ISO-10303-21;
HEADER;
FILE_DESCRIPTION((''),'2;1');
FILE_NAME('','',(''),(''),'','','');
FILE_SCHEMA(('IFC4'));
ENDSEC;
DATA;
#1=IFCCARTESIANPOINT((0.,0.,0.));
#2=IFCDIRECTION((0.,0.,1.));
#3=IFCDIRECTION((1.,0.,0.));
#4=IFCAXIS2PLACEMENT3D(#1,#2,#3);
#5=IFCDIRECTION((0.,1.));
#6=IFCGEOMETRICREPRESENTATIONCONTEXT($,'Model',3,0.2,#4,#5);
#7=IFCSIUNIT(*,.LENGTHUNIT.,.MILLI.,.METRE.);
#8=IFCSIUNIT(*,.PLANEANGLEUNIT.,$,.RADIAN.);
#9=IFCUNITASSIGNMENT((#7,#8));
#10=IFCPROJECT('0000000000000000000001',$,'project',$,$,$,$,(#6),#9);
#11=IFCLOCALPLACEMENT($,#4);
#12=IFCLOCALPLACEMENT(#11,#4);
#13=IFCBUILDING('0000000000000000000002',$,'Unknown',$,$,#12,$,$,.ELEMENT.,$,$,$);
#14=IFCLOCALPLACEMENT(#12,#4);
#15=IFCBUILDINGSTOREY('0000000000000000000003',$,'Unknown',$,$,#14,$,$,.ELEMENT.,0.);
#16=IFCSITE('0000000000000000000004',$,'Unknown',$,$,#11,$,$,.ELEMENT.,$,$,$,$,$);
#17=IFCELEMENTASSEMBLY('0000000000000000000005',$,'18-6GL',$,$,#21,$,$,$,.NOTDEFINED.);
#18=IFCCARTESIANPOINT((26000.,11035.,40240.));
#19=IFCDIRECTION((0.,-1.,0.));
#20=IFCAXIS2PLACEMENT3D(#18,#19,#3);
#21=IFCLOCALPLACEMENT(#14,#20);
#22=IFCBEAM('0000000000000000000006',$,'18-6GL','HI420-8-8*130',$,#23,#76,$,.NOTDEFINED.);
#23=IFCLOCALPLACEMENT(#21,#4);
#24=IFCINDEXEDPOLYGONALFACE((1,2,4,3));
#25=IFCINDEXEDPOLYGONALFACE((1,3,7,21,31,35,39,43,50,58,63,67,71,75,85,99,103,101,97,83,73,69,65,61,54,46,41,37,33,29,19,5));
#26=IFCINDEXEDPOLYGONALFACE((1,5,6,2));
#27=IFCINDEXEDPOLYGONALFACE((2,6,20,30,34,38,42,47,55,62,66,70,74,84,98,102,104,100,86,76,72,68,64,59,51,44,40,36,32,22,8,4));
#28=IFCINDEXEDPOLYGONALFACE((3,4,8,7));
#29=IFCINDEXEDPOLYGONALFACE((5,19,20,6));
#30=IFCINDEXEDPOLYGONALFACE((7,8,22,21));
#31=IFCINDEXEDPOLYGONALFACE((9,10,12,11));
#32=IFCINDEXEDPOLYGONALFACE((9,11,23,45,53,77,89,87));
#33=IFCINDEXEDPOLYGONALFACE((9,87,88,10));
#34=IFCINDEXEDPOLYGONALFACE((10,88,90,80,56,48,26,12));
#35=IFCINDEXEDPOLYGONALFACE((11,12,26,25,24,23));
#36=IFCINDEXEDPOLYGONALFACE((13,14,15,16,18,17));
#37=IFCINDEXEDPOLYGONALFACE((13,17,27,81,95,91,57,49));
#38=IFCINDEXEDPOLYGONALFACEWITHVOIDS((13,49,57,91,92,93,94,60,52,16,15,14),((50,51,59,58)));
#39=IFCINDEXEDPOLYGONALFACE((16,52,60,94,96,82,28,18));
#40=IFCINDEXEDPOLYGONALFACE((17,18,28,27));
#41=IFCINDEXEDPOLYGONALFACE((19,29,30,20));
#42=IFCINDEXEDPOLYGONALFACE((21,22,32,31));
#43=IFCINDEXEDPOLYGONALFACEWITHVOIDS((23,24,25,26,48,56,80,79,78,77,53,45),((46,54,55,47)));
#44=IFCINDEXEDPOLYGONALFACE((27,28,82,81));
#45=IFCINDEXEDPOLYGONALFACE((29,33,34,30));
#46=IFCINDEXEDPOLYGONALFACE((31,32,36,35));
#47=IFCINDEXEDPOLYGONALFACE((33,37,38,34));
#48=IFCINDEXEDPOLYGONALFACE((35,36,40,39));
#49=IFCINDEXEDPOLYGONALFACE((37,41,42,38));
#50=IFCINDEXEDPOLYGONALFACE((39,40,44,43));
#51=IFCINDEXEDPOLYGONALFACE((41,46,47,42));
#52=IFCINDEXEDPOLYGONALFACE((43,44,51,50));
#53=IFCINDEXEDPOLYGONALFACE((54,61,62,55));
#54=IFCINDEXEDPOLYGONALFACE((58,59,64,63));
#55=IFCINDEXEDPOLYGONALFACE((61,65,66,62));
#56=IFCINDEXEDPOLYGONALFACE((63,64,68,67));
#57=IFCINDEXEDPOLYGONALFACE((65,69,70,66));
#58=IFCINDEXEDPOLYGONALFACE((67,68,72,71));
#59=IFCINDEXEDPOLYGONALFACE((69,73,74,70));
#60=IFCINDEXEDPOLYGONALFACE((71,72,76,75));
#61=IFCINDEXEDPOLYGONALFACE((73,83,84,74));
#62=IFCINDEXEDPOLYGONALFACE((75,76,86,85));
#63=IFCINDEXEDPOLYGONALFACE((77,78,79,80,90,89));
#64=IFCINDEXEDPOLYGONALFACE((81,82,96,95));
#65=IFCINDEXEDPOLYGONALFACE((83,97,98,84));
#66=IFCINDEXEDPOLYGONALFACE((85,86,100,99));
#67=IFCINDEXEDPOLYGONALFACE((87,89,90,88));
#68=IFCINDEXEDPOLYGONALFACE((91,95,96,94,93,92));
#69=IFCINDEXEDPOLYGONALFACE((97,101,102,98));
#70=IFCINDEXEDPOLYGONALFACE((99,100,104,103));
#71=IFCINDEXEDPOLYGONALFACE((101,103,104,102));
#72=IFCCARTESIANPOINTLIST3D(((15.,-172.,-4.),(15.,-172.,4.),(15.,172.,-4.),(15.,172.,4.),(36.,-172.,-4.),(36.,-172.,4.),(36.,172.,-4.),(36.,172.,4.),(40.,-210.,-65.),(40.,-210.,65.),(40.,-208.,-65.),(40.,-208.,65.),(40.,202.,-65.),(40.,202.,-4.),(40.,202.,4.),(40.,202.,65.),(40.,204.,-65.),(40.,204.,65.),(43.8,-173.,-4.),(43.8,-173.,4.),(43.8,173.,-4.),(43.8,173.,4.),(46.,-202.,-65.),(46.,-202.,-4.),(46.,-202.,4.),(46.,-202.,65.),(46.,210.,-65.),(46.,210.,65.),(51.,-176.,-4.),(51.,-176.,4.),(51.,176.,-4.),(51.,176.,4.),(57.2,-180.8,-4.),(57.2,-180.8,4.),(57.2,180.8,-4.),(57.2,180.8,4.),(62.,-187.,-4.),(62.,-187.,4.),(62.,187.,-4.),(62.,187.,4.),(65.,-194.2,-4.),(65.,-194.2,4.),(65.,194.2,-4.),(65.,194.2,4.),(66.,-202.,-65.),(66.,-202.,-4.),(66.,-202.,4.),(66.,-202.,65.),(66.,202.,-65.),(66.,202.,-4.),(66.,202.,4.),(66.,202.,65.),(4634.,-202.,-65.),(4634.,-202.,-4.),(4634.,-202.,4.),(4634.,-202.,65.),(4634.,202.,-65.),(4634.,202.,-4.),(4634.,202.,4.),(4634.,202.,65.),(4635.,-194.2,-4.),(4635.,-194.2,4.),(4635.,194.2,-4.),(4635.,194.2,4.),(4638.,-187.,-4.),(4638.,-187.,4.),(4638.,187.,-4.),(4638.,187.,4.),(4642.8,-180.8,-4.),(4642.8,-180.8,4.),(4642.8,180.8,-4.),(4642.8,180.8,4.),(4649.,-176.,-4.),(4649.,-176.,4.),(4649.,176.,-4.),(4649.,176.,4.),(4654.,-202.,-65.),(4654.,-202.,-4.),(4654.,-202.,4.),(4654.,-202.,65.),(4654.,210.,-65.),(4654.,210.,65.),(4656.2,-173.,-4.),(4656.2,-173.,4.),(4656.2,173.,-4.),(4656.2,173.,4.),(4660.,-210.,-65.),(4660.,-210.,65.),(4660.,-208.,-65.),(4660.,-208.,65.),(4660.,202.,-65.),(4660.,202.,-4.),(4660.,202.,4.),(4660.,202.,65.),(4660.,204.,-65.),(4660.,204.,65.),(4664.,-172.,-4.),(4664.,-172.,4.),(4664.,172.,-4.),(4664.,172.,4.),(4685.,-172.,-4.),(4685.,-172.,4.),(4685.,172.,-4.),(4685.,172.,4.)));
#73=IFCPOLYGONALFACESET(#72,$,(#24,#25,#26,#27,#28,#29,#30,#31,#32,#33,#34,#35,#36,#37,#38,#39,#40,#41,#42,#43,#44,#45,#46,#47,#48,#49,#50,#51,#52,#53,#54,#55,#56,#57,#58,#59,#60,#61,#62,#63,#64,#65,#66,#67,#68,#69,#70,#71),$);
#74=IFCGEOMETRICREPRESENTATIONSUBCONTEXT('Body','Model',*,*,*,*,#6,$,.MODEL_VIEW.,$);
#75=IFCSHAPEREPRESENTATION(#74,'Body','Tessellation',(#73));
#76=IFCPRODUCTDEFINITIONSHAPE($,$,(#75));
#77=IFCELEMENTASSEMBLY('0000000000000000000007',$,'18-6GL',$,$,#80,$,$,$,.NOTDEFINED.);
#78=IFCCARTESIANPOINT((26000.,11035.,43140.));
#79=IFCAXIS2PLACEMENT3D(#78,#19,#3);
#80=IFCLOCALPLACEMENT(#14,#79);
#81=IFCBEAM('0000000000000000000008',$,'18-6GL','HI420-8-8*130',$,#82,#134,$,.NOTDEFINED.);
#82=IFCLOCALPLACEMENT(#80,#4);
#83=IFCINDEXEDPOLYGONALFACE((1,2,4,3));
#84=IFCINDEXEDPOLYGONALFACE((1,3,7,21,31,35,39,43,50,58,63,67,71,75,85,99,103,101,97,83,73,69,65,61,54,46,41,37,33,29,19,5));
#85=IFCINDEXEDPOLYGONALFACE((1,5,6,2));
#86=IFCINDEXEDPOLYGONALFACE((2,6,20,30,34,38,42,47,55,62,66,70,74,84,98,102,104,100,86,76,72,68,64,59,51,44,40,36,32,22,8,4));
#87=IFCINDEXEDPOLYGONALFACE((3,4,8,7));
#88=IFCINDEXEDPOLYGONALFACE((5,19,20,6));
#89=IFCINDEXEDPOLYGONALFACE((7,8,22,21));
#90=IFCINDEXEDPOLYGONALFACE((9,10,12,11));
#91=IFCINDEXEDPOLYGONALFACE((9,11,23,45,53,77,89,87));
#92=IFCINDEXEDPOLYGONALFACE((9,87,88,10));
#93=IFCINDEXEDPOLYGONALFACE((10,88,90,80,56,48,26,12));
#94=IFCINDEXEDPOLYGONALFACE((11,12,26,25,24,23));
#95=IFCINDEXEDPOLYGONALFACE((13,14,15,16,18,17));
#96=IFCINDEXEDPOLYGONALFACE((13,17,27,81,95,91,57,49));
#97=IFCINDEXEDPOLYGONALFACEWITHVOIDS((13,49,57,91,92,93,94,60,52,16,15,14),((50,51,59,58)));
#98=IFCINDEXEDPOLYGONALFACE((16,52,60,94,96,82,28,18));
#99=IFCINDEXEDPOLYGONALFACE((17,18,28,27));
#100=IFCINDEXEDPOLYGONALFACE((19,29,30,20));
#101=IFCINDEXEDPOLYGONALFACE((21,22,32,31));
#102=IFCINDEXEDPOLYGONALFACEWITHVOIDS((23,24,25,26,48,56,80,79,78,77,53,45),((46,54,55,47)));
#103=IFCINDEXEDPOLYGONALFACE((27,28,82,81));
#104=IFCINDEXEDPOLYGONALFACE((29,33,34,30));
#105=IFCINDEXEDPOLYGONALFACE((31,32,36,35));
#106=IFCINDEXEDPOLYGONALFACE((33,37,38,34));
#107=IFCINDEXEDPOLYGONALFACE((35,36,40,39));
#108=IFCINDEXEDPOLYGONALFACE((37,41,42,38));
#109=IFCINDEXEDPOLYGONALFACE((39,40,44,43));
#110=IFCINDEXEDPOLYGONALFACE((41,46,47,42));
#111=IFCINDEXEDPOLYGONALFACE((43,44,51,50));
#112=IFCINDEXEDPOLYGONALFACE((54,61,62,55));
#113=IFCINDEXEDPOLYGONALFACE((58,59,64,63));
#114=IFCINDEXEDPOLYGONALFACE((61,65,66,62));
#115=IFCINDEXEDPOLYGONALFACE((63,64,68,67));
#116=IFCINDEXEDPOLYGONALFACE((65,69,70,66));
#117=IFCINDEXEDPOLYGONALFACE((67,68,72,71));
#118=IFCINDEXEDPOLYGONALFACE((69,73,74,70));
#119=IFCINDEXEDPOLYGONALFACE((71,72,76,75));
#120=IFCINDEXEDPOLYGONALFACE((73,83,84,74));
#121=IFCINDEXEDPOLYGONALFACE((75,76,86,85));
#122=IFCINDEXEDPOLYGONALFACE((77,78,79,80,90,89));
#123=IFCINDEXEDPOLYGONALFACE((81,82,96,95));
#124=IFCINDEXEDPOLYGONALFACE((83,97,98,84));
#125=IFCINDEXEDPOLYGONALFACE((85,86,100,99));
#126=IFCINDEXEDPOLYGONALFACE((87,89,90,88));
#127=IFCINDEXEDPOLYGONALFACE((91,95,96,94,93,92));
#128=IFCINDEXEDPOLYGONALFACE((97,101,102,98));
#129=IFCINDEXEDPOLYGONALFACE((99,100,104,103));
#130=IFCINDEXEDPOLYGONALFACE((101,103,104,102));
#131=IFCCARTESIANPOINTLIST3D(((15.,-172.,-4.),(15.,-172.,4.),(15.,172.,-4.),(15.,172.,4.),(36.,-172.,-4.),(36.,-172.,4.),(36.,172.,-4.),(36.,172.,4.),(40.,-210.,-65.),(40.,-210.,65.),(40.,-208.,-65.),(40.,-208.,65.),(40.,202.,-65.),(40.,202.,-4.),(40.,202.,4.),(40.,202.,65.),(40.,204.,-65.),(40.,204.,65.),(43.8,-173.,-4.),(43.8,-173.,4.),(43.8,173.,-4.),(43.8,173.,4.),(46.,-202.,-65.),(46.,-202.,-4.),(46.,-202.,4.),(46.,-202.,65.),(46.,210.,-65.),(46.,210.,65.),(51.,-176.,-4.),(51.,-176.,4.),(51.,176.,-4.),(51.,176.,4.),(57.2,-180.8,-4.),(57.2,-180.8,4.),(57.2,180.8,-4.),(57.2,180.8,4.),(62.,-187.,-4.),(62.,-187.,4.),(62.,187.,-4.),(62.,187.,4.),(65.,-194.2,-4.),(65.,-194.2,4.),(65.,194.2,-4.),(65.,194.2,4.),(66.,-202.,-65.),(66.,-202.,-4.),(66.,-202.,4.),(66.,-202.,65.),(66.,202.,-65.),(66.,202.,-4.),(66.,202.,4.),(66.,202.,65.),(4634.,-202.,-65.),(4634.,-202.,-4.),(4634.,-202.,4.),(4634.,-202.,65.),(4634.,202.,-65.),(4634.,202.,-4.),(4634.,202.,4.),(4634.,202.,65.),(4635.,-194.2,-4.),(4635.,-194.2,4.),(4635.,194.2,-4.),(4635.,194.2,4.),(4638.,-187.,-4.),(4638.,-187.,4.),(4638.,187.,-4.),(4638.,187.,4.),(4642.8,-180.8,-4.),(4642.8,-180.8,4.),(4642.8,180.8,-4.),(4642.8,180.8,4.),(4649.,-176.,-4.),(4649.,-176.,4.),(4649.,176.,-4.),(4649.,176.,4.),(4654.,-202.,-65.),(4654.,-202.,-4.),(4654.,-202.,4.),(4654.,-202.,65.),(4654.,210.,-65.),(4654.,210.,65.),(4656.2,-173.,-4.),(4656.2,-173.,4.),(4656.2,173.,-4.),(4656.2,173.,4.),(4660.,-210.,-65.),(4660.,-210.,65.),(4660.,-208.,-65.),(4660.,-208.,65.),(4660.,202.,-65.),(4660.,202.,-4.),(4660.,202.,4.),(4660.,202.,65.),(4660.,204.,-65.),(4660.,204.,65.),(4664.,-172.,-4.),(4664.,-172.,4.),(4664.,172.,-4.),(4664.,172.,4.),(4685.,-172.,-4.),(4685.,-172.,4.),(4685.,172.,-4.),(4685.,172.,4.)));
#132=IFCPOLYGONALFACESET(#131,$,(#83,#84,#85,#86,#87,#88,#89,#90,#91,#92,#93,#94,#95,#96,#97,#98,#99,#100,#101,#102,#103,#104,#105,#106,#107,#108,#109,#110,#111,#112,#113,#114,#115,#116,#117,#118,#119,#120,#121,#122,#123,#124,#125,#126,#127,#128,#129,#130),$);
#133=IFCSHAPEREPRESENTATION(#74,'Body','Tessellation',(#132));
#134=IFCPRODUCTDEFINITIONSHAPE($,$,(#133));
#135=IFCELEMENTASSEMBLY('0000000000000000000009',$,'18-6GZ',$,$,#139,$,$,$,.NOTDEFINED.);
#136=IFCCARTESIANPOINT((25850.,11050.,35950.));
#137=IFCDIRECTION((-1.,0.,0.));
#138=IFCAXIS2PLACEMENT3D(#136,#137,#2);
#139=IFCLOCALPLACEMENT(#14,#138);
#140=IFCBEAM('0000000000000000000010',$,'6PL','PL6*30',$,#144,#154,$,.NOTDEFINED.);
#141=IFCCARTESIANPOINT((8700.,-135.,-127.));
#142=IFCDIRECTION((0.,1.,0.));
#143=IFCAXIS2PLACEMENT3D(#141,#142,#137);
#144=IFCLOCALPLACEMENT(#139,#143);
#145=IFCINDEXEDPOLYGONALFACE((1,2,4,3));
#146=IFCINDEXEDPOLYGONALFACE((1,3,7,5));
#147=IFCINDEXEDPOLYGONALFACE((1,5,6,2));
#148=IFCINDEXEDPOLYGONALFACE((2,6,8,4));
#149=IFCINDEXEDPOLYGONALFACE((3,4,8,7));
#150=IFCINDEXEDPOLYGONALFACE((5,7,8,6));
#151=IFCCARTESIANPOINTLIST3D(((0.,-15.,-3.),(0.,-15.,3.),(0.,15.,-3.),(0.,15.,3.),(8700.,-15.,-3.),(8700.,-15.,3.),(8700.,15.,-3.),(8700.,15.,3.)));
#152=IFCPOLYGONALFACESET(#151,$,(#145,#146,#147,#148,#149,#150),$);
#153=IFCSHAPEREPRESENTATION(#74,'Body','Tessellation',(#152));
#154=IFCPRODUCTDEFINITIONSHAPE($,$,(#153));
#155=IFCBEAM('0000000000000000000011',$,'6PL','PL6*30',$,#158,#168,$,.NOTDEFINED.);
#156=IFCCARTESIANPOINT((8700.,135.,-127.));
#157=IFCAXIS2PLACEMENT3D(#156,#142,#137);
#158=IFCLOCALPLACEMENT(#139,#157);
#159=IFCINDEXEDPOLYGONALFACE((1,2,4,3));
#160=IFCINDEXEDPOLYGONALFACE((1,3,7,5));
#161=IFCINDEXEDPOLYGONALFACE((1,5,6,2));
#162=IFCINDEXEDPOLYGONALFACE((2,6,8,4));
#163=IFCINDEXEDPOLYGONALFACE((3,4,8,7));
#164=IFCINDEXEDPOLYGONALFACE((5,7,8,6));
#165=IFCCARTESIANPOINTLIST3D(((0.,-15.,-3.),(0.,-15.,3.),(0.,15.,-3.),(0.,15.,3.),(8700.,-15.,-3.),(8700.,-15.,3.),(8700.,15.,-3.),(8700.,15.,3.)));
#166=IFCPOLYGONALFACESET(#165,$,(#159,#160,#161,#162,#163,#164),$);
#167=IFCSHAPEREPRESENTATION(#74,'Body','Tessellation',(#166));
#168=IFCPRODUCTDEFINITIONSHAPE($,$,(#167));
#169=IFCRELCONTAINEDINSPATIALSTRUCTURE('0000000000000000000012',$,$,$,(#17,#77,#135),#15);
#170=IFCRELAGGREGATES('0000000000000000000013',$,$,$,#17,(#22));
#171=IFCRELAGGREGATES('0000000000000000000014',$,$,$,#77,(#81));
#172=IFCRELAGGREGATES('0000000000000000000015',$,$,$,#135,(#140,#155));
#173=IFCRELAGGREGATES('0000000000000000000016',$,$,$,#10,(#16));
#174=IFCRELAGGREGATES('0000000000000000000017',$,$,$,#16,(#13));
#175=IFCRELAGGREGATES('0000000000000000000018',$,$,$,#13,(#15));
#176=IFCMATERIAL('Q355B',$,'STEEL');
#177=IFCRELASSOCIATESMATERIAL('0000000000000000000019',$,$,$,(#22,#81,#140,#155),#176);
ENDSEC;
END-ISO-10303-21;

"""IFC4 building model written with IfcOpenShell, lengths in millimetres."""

from ifc_helpers import new_model, si_unit, direction, frame, origin_with_axes, place, context, subcontext, project, spatial, line, arc, indexed_curve, outline, extrude, material, element, aggregate, save


model = new_model("IFC4")

# Units and contexts
model_context = context("Model", 3, precision=0.2, world=origin_with_axes(), true_north=direction((0.0, 1.0)))
body_context = subcontext(model_context, "Body", "Model", "MODEL_VIEW")
ifc_project = project(units=[si_unit("LENGTHUNIT", "METRE", prefix="MILLI"), si_unit("PLANEANGLEUNIT", "RADIAN")], contexts=[model_context])

# Site, building, storey
site_placement = place(None, origin_with_axes())
site = spatial("IfcSite", under=ifc_project, at=site_placement, Name="Unknown", CompositionType="ELEMENT")
building_placement = place(site_placement, origin_with_axes())
building = spatial("IfcBuilding", under=site, at=building_placement, Name="Unknown", CompositionType="ELEMENT")
storey_placement = place(building_placement, origin_with_axes())
storey = spatial("IfcBuildingStorey", under=building, at=storey_placement, Name="Unknown", CompositionType="ELEMENT", Elevation=0.0)

# Element assembly, beam, voiding features
assembly_1_placement = place(storey_placement, frame((26000.0, 11035.0, 40240.0), z_axis=(0.0, -1.0, 0.0), x_axis=(1.0, 0.0, 0.0)))
assembly_1 = element("IfcElementAssembly", 1, at=assembly_1_placement, inside=storey, Name="18-6GL", PredefinedType="NOTDEFINED")
ifc_material_1 = material(Name="Q355B", Category="STEEL")
beam_1_placement = place(assembly_1_placement, origin_with_axes())
beam_1 = element("IfcBeam", 2, at=beam_1_placement, material=ifc_material_1, Name="18-6GL", Description="HI420-8-8*130", PredefinedType="NOTDEFINED", context=body_context, shape_type="SolidModel", body=[
    extrude(outline(indexed_curve([(-65.0, -210.0), (65.0, -210.0), (65.0, -202.0), (4.0, -202.0), (4.0, 202.0), (65.0, 202.0), (65.0, 210.0), (-65.0, 210.0), (-65.0, 202.0), (-4.0, 202.0), (-4.0, -202.0), (-65.0, -202.0)], segments=[line(1, 2, 3, 4, 5, 6, 7, 8, 9, 10, 11, 12, 1)])), frame((0.0, 0.0, 0.0), z_axis=(-1.0, 0.0, 0.0), x_axis=(0.0, 0.0, 1.0)), (0.0, 0.0, -1.0), 4700.0),
])
voiding_feature_1_placement = place(beam_1_placement, frame((4700.0, 210.0, 0.0), z_axis=(0.0, 0.0, 1.0), x_axis=(-1.0, 0.0, 0.0)))
element("IfcVoidingFeature", 3, at=voiding_feature_1_placement, cuts=beam_1, Name="CUTPART", PredefinedType="HOLE", context=body_context, shape_type="SolidModel", body=[
    extrude(outline(indexed_curve([(0.0, 0.0), (46.0, 0.0), (40.0, 6.0), (40.0, 8.0), (66.0, 8.0), (57.2, 29.2), (36.0, 38.0), (15.0, 38.0), (15.0, 382.0), (36.0, 382.0), (57.2, 390.8), (66.0, 412.0), (46.0, 412.0), (40.0, 418.0), (40.0, 420.0), (0.0, 420.0)], segments=[line(1, 2, 3, 4, 5), arc(5, 6, 7), line(7, 8, 9, 10), arc(10, 11, 12), line(12, 13, 14, 15, 16, 1)])), frame((0.0, 0.0, 67.5), z_axis=(0.0, 0.0, 1.0), x_axis=(1.0, 0.0, 0.0)), (0.0, 0.0, -1.0), 135.0),
])
voiding_feature_2_placement = place(beam_1_placement, frame((0.0, 210.0, 0.0), z_axis=(0.0, 0.0, -1.0), x_axis=(1.0, 0.0, 0.0)))
element("IfcVoidingFeature", 4, at=voiding_feature_2_placement, cuts=beam_1, Name="CUTPART", PredefinedType="HOLE", context=body_context, shape_type="SolidModel", body=[
    extrude(outline(indexed_curve([(0.0, 0.0), (46.0, 0.0), (40.0, 6.0), (40.0, 8.0), (66.0, 8.0), (57.2, 29.2), (36.0, 38.0), (15.0, 38.0), (15.0, 382.0), (36.0, 382.0), (57.2, 390.8), (66.0, 412.0), (46.0, 412.0), (40.0, 418.0), (40.0, 420.0), (0.0, 420.0)], segments=[line(1, 2, 3, 4, 5), arc(5, 6, 7), line(7, 8, 9, 10), arc(10, 11, 12), line(12, 13, 14, 15, 16, 1)])), frame((0.0, 0.0, 67.5), z_axis=(0.0, 0.0, 1.0), x_axis=(1.0, 0.0, 0.0)), (0.0, 0.0, -1.0), 135.0),
])

# Element assembly, beam, voiding features
assembly_2_placement = place(storey_placement, frame((26000.0, 11035.0, 43140.0), z_axis=(0.0, -1.0, 0.0), x_axis=(1.0, 0.0, 0.0)))
assembly_2 = element("IfcElementAssembly", 5, at=assembly_2_placement, inside=storey, Name="18-6GL", PredefinedType="NOTDEFINED")
beam_2_placement = place(assembly_2_placement, origin_with_axes())
beam_2 = element("IfcBeam", 6, at=beam_2_placement, material=ifc_material_1, Name="18-6GL", Description="HI420-8-8*130", PredefinedType="NOTDEFINED", context=body_context, shape_type="SolidModel", body=[
    extrude(outline(indexed_curve([(-65.0, -210.0), (65.0, -210.0), (65.0, -202.0), (4.0, -202.0), (4.0, 202.0), (65.0, 202.0), (65.0, 210.0), (-65.0, 210.0), (-65.0, 202.0), (-4.0, 202.0), (-4.0, -202.0), (-65.0, -202.0)], segments=[line(1, 2, 3, 4, 5, 6, 7, 8, 9, 10, 11, 12, 1)])), frame((0.0, 0.0, 0.0), z_axis=(-1.0, 0.0, 0.0), x_axis=(0.0, 0.0, 1.0)), (0.0, 0.0, -1.0), 4700.0),
])
voiding_feature_3_placement = place(beam_2_placement, frame((4700.0, 210.0, 0.0), z_axis=(0.0, 0.0, 1.0), x_axis=(-1.0, 0.0, 0.0)))
element("IfcVoidingFeature", 7, at=voiding_feature_3_placement, cuts=beam_2, Name="CUTPART", PredefinedType="HOLE", context=body_context, shape_type="SolidModel", body=[
    extrude(outline(indexed_curve([(0.0, 0.0), (46.0, 0.0), (40.0, 6.0), (40.0, 8.0), (66.0, 8.0), (57.2, 29.2), (36.0, 38.0), (15.0, 38.0), (15.0, 382.0), (36.0, 382.0), (57.2, 390.8), (66.0, 412.0), (46.0, 412.0), (40.0, 418.0), (40.0, 420.0), (0.0, 420.0)], segments=[line(1, 2, 3, 4, 5), arc(5, 6, 7), line(7, 8, 9, 10), arc(10, 11, 12), line(12, 13, 14, 15, 16, 1)])), frame((0.0, 0.0, 67.5), z_axis=(0.0, 0.0, 1.0), x_axis=(1.0, 0.0, 0.0)), (0.0, 0.0, -1.0), 135.0),
])
voiding_feature_4_placement = place(beam_2_placement, frame((0.0, 210.0, 0.0), z_axis=(0.0, 0.0, -1.0), x_axis=(1.0, 0.0, 0.0)))
element("IfcVoidingFeature", 8, at=voiding_feature_4_placement, cuts=beam_2, Name="CUTPART", PredefinedType="HOLE", context=body_context, shape_type="SolidModel", body=[
    extrude(outline(indexed_curve([(0.0, 0.0), (46.0, 0.0), (40.0, 6.0), (40.0, 8.0), (66.0, 8.0), (57.2, 29.2), (36.0, 38.0), (15.0, 38.0), (15.0, 382.0), (36.0, 382.0), (57.2, 390.8), (66.0, 412.0), (46.0, 412.0), (40.0, 418.0), (40.0, 420.0), (0.0, 420.0)], segments=[line(1, 2, 3, 4, 5), arc(5, 6, 7), line(7, 8, 9, 10), arc(10, 11, 12), line(12, 13, 14, 15, 16, 1)])), frame((0.0, 0.0, 67.5), z_axis=(0.0, 0.0, 1.0), x_axis=(1.0, 0.0, 0.0)), (0.0, 0.0, -1.0), 135.0),
])

# Element assembly, beams
assembly_3_placement = place(storey_placement, frame((25850.0, 11050.0, 35950.0), z_axis=(-1.0, 0.0, 0.0), x_axis=(0.0, 0.0, 1.0)))
assembly_3 = element("IfcElementAssembly", 9, at=assembly_3_placement, inside=storey, Name="18-6GZ", PredefinedType="NOTDEFINED")
beam_3_placement = place(assembly_3_placement, frame((8700.0, -135.0, -127.0), z_axis=(0.0, 1.0, 0.0), x_axis=(-1.0, 0.0, 0.0)))
beam_3 = element("IfcBeam", 10, at=beam_3_placement, material=ifc_material_1, Name="6PL", Description="PL6*30", PredefinedType="NOTDEFINED", context=body_context, shape_type="SolidModel", body=[
    extrude(outline(indexed_curve([(-3.0, -15.0), (3.0, -15.0), (3.0, 15.0), (-3.0, 15.0)], segments=[line(1, 2, 3, 4, 1)])), frame((0.0, 0.0, 0.0), z_axis=(-1.0, 0.0, 0.0), x_axis=(0.0, 0.0, 1.0)), (0.0, 0.0, -1.0), 8700.0),
])
beam_4_placement = place(assembly_3_placement, frame((8700.0, 135.0, -127.0), z_axis=(0.0, 1.0, 0.0), x_axis=(-1.0, 0.0, 0.0)))
beam_4 = element("IfcBeam", 11, at=beam_4_placement, material=ifc_material_1, Name="6PL", Description="PL6*30", PredefinedType="NOTDEFINED", context=body_context, shape_type="SolidModel", body=[
    extrude(outline(indexed_curve([(-3.0, -15.0), (3.0, -15.0), (3.0, 15.0), (-3.0, 15.0)], segments=[line(1, 2, 3, 4, 1)])), frame((0.0, 0.0, 0.0), z_axis=(-1.0, 0.0, 0.0), x_axis=(0.0, 0.0, 1.0)), (0.0, 0.0, -1.0), 8700.0),
])

aggregate(assembly_1, [beam_1])
aggregate(assembly_2, [beam_2])

aggregate(assembly_3, [beam_3, beam_4])

save(model, "model.ifc")
